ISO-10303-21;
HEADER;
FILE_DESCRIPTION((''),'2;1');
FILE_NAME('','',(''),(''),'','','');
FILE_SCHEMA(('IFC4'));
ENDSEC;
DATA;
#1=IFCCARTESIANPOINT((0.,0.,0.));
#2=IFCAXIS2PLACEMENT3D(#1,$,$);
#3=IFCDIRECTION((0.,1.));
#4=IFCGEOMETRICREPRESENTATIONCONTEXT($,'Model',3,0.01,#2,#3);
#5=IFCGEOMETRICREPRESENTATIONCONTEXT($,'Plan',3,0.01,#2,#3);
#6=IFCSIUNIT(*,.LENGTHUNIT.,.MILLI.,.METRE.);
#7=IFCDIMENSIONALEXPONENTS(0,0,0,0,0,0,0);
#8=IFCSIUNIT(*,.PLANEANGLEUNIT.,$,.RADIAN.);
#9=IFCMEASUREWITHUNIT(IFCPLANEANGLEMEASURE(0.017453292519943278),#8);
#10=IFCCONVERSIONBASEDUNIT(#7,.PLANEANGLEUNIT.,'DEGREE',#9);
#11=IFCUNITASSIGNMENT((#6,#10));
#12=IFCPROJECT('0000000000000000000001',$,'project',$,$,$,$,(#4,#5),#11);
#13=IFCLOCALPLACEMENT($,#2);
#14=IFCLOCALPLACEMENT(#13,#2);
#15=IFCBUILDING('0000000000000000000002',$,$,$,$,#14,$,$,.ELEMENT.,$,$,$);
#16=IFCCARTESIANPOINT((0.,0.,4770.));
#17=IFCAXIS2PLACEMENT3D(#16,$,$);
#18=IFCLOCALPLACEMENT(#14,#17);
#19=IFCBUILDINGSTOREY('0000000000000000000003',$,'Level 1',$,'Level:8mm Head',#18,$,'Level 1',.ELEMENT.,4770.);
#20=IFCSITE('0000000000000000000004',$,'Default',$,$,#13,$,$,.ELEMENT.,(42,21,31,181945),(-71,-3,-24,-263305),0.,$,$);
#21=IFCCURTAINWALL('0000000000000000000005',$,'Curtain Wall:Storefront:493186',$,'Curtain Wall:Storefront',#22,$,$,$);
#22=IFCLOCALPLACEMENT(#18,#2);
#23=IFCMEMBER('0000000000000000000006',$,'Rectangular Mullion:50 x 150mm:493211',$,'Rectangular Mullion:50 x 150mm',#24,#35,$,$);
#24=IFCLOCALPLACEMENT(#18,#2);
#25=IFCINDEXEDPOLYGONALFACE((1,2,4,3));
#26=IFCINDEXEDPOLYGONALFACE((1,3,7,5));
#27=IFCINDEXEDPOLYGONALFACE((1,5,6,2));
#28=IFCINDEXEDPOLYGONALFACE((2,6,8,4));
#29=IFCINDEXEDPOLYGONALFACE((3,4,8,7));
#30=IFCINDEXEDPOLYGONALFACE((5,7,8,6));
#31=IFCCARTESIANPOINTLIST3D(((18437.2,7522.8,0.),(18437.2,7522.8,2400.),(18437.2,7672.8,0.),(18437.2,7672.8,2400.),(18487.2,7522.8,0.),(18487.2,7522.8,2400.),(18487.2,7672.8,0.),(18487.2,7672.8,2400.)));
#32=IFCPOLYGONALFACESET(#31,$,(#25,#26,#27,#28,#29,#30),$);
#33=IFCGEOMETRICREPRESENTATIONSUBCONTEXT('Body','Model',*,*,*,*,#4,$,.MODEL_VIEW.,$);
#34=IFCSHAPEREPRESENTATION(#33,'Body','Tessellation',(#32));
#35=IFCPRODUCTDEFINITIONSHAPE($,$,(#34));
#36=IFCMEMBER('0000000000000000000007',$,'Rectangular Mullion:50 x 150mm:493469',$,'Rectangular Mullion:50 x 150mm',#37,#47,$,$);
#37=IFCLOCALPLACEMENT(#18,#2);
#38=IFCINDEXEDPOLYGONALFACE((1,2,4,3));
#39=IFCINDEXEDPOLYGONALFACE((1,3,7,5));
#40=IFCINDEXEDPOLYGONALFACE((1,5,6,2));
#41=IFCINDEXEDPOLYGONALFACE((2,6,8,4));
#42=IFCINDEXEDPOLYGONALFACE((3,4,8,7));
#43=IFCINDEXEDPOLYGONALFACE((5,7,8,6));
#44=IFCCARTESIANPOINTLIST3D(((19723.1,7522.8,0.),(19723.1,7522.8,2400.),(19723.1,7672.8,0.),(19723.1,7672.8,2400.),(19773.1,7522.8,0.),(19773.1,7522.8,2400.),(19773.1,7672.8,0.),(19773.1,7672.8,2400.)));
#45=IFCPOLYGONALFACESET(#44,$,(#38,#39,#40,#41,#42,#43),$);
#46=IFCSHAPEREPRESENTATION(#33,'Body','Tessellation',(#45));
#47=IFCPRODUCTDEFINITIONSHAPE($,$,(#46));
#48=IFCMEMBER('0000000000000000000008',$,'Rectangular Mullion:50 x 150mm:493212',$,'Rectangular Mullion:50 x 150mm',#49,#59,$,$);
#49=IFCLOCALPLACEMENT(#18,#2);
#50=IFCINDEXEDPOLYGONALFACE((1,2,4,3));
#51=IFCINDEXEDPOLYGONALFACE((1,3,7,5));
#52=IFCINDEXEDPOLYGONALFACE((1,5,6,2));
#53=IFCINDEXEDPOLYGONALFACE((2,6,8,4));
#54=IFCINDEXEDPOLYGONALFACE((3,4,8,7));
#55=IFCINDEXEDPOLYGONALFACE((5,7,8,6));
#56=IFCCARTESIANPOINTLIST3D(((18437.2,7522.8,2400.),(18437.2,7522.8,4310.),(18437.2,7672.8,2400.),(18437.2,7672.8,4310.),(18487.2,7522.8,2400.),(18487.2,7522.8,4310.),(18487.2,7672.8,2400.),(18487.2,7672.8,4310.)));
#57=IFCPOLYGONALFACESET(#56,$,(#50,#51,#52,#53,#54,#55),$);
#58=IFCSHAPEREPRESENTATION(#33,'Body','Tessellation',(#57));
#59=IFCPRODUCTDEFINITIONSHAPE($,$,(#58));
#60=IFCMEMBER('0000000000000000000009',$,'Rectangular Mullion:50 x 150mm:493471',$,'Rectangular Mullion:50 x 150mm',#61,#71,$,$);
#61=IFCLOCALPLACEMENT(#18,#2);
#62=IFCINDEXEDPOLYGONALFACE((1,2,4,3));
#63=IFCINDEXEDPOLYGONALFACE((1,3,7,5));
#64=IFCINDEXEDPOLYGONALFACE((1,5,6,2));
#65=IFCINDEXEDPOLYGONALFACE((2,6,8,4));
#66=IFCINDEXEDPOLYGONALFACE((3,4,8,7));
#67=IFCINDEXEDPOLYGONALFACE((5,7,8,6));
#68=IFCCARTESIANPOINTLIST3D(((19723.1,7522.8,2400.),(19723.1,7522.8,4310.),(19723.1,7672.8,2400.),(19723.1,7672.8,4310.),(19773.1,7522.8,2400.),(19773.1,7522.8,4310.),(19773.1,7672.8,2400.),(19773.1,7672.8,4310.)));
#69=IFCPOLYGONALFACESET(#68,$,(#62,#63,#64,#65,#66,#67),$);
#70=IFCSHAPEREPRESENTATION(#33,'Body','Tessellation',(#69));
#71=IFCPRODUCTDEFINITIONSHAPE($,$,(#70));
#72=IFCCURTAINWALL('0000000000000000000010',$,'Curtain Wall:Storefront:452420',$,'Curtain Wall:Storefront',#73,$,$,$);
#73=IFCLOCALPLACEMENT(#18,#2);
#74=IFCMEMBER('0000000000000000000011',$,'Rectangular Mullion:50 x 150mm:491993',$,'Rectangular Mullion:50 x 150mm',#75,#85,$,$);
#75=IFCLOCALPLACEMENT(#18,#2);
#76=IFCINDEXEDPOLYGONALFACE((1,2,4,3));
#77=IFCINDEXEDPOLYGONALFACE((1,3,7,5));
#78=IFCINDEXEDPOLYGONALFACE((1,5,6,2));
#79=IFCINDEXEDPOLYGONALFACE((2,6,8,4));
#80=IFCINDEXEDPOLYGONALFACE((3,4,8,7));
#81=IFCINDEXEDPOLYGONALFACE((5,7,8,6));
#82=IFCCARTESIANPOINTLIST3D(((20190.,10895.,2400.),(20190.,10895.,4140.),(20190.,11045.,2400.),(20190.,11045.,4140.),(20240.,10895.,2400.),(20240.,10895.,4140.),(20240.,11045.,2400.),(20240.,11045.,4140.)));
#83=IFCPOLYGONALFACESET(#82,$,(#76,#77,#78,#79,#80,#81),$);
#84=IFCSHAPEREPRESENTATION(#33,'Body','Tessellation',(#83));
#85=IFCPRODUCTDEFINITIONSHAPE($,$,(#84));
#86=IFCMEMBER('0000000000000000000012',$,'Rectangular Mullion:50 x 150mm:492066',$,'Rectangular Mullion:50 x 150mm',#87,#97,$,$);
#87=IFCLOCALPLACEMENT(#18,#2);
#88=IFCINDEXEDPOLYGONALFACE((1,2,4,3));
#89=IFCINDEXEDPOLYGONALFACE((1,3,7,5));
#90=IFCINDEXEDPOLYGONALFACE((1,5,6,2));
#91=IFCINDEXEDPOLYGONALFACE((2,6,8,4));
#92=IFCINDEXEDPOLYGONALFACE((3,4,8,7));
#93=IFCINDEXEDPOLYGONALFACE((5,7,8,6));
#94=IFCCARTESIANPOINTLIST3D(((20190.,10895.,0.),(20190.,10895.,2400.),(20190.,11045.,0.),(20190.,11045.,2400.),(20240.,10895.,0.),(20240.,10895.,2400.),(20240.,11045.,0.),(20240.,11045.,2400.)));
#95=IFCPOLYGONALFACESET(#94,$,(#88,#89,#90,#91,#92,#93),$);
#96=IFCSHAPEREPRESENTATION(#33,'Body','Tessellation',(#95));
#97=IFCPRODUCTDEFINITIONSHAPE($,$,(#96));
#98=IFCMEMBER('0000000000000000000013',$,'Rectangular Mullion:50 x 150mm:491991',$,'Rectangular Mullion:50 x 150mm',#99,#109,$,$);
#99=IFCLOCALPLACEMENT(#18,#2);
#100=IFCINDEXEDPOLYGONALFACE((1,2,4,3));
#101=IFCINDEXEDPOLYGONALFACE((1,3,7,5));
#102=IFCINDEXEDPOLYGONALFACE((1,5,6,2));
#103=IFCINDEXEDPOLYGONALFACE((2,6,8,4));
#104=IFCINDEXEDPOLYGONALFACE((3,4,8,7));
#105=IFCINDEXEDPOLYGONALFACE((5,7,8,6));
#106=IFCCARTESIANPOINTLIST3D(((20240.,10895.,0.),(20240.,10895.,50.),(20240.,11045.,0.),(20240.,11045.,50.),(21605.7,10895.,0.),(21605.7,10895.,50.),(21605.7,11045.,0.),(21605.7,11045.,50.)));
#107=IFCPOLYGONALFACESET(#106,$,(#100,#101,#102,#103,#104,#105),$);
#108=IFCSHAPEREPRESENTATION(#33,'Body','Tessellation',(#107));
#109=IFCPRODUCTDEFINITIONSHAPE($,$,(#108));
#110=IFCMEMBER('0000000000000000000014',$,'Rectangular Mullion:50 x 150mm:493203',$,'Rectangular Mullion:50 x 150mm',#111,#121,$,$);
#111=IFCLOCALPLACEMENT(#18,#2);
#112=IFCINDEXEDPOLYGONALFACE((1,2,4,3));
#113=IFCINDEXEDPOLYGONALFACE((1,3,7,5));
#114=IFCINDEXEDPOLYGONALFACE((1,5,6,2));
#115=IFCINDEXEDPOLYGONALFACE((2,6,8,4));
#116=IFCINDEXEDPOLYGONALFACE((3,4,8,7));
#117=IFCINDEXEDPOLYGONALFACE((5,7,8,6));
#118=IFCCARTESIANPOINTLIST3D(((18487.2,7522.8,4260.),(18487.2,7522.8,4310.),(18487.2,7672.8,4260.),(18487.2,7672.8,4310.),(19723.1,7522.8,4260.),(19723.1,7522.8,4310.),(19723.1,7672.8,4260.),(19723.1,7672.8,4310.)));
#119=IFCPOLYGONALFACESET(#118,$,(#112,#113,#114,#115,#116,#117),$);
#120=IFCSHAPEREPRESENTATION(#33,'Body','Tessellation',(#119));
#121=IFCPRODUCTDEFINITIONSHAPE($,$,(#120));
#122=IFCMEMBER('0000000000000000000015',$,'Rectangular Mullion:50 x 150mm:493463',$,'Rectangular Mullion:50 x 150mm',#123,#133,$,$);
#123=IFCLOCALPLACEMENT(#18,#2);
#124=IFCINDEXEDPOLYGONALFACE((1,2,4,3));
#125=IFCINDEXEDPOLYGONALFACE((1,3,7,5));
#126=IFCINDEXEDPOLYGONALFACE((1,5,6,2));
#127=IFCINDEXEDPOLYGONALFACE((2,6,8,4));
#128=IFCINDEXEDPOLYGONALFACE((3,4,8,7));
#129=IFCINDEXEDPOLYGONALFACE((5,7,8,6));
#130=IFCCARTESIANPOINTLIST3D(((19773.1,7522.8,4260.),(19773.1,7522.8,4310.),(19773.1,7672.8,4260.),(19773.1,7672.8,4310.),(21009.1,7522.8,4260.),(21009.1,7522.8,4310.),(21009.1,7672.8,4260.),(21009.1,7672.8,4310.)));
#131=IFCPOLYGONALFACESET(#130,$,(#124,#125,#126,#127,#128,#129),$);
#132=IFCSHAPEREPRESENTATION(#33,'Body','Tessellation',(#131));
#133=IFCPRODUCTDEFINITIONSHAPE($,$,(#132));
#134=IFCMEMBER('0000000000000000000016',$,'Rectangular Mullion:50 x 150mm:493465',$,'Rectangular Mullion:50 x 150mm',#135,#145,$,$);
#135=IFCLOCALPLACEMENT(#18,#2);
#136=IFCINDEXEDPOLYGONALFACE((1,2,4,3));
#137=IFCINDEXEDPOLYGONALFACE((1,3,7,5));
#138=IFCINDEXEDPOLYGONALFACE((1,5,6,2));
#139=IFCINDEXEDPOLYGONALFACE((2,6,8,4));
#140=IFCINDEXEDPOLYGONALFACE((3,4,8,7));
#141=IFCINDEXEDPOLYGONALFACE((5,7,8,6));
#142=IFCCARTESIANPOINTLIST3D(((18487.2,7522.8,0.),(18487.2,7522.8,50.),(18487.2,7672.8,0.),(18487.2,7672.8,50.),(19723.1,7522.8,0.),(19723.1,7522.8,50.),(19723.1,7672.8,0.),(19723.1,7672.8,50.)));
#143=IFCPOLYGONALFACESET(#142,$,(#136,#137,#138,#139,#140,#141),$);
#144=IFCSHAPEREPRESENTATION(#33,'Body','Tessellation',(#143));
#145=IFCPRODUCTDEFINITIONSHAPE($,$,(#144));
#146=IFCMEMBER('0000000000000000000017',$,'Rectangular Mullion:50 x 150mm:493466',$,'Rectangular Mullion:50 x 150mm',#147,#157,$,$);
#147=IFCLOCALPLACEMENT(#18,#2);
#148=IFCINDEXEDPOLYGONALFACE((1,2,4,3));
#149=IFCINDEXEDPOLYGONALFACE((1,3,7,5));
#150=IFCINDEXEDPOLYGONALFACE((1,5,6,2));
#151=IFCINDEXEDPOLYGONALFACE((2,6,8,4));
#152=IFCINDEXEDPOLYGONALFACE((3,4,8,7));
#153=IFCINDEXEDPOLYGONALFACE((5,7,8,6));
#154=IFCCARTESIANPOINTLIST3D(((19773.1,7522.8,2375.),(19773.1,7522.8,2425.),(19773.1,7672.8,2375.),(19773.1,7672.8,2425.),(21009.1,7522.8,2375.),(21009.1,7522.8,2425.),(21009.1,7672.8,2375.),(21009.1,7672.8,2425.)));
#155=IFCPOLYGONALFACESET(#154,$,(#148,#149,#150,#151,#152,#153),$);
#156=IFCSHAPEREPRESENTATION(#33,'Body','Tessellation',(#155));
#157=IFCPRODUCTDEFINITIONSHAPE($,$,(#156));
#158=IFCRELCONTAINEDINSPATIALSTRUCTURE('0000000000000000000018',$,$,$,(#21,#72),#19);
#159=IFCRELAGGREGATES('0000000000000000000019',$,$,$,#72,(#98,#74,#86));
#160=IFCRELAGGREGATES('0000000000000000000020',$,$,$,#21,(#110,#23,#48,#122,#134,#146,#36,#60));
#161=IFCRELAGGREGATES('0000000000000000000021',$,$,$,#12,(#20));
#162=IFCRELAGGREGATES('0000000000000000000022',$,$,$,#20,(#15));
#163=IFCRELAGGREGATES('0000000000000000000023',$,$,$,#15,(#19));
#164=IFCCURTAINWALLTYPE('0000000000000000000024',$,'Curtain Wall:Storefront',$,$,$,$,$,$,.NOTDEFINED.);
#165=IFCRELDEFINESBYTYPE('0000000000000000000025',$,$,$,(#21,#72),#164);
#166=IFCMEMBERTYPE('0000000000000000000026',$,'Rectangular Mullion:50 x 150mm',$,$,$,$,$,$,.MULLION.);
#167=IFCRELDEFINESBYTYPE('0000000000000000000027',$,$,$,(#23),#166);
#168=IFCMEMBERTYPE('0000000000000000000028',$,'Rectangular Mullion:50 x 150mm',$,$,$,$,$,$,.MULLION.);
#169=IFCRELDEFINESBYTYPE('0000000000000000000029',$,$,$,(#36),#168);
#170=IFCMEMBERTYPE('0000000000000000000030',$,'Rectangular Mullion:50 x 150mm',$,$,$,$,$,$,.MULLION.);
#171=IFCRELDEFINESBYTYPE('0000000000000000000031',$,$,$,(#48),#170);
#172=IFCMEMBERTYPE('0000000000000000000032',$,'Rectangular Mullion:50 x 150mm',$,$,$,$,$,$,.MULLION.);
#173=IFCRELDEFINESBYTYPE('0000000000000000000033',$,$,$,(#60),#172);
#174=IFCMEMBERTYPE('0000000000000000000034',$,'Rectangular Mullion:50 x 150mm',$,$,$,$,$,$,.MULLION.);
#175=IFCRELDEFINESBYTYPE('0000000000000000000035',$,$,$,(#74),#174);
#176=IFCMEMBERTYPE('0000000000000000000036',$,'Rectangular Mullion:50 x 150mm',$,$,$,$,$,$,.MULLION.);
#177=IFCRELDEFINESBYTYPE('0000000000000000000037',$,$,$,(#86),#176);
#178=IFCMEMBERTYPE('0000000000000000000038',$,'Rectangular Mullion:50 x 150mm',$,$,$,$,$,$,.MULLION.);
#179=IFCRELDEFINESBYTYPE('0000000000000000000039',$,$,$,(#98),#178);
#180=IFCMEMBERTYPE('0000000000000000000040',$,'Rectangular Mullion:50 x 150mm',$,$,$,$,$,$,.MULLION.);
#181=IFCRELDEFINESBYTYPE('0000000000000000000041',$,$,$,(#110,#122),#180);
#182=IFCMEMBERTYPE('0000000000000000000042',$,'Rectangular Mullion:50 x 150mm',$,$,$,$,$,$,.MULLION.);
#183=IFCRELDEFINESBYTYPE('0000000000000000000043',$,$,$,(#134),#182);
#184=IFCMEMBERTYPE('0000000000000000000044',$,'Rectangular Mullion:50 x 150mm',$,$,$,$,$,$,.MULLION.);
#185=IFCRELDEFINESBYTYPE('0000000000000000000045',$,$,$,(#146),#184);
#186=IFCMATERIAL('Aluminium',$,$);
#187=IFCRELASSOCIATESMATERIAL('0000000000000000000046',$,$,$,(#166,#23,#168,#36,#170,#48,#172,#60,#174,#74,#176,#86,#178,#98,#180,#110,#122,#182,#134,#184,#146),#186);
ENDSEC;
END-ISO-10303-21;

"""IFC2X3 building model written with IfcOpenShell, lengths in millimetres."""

from ifc_helpers import new_model, entity, si_unit, converted_unit, direction, frame, origin, origin_2d_with_axis, place, context, subcontext, project, spatial, rectangle, extrude, source, transform, mapped, material, type_object, type_shapes, element, aggregate, save


model = new_model("IFC2X3")

# Units and contexts
model_context = context("Model", 3, precision=0.01, world=origin(), true_north=direction((0.0, 1.0)))
plan_context = context("Plan", 3, precision=0.01, world=origin(), true_north=direction((0.0, 1.0)))
body_context = subcontext(model_context, "Body", "Model", "MODEL_VIEW")
ifc_project = project(units=[si_unit("LENGTHUNIT", "METRE", prefix="MILLI"), converted_unit("PLANEANGLEUNIT", "DEGREE", entity("IfcPlaneAngleMeasure", 0.017453292519943278), si_unit("PLANEANGLEUNIT", "RADIAN"), dimensions=[0, 0, 0, 0, 0, 0, 0])], contexts=[model_context, plan_context])

# Site, building, storey
site_placement = place(None, origin())
site = spatial("IfcSite", under=ifc_project, at=site_placement, Name="Default", CompositionType="ELEMENT", RefLatitude=(42, 21, 31, 181945), RefLongitude=(-71, -3, -24, -263305), RefElevation=0.0)
building_placement = place(site_placement, origin())
building = spatial("IfcBuilding", under=site, at=building_placement, CompositionType="ELEMENT")
storey_placement = place(building_placement, frame((0.0, 0.0, 4770.0)))
storey = spatial("IfcBuildingStorey", under=building, at=storey_placement, Name="Level 1", ObjectType="Level:8mm Head", LongName="Level 1", CompositionType="ELEMENT", Elevation=4770.0)

# Curtain walls, members
curtain_wall_type = type_object("IfcCurtainWallType", Name="Curtain Wall:Storefront", PredefinedType="NOTDEFINED")
curtain_wall_1_placement = place(storey_placement, frame((0.0, 0.0, -4770.0)))
curtain_wall_1 = element("IfcCurtainWall", 1, at=curtain_wall_1_placement, inside=storey, type_object=curtain_wall_type, Name="Curtain Wall:Storefront:493186", ObjectType="Curtain Wall:Storefront")
ifc_material_1 = material(Name="Aluminium")
member_type_1 = type_object("IfcMemberType", Name="Rectangular Mullion:50 x 150mm", PredefinedType="MULLION", material=ifc_material_1)
shared_shape_1 = source(origin(), body_context, "Body", "SweptSolid", [
    extrude(rectangle(XDim=50.0, YDim=150.0, at=origin_2d_with_axis()), frame((-25.0, 0.0, -2400.0), z_axis=(0.0, 0.0, 1.0), x_axis=(-1.0, 0.0, 0.0)), (0.0, 0.0, 1.0), 2400.0),
])
type_shapes(member_type_1, [shared_shape_1])
member_1_placement = place(curtain_wall_1_placement, frame((18437.2, 7597.8, 4770.0), z_axis=(0.0, 0.0, -1.0), x_axis=(-1.0, 0.0, 0.0)))
member_1 = element("IfcMember", 2, at=member_1_placement, type_object=member_type_1, material=ifc_material_1, Name="Rectangular Mullion:50 x 150mm:493211", ObjectType="Rectangular Mullion:50 x 150mm", context=body_context, shape_type="MappedRepresentation", body=[
    mapped(shared_shape_1, transform((0.0, 0.0, 0.0), scale=1.0)),
])
member_type_2 = type_object("IfcMemberType", Name="Rectangular Mullion:50 x 150mm", PredefinedType="MULLION", material=ifc_material_1)
shared_shape_2 = source(origin(), body_context, "Body", "SweptSolid", [
    extrude(rectangle(XDim=50.0, YDim=150.0, at=origin_2d_with_axis()), frame((0.0, 0.0, -2400.0), z_axis=(0.0, 0.0, 1.0), x_axis=(-1.0, 0.0, 0.0)), (0.0, 0.0, 1.0), 2400.0),
])
type_shapes(member_type_2, [shared_shape_2])
member_2_placement = place(curtain_wall_1_placement, frame((19748.1, 7597.8, 4770.0), z_axis=(0.0, 0.0, -1.0), x_axis=(-1.0, 0.0, 0.0)))
member_2 = element("IfcMember", 3, at=member_2_placement, type_object=member_type_2, material=ifc_material_1, Name="Rectangular Mullion:50 x 150mm:493469", ObjectType="Rectangular Mullion:50 x 150mm", context=body_context, shape_type="MappedRepresentation", body=[
    mapped(shared_shape_2, transform((0.0, 0.0, 0.0), scale=1.0)),
])
member_type_3 = type_object("IfcMemberType", Name="Rectangular Mullion:50 x 150mm", PredefinedType="MULLION", material=ifc_material_1)
shared_shape_3 = source(origin(), body_context, "Body", "SweptSolid", [
    extrude(rectangle(XDim=50.0, YDim=150.0, at=origin_2d_with_axis()), frame((-25.0, 0.0, -1910.0), z_axis=(0.0, 0.0, 1.0), x_axis=(-1.0, 0.0, 0.0)), (0.0, 0.0, 1.0), 1910.0),
])
type_shapes(member_type_3, [shared_shape_3])
member_3_placement = place(curtain_wall_1_placement, frame((18437.2, 7597.8, 7170.0), z_axis=(0.0, 0.0, -1.0), x_axis=(-1.0, 0.0, 0.0)))
member_3 = element("IfcMember", 4, at=member_3_placement, type_object=member_type_3, material=ifc_material_1, Name="Rectangular Mullion:50 x 150mm:493212", ObjectType="Rectangular Mullion:50 x 150mm", context=body_context, shape_type="MappedRepresentation", body=[
    mapped(shared_shape_3, transform((0.0, 0.0, 0.0), scale=1.0)),
])
member_type_4 = type_object("IfcMemberType", Name="Rectangular Mullion:50 x 150mm", PredefinedType="MULLION", material=ifc_material_1)
shared_shape_4 = source(origin(), body_context, "Body", "SweptSolid", [
    extrude(rectangle(XDim=50.0, YDim=150.0, at=origin_2d_with_axis()), frame((0.0, 0.0, -1910.0), z_axis=(0.0, 0.0, 1.0), x_axis=(-1.0, 0.0, 0.0)), (0.0, 0.0, 1.0), 1910.0),
])
type_shapes(member_type_4, [shared_shape_4])
member_4_placement = place(curtain_wall_1_placement, frame((19748.1, 7597.8, 7170.0), z_axis=(0.0, 0.0, -1.0), x_axis=(-1.0, 0.0, 0.0)))
member_4 = element("IfcMember", 5, at=member_4_placement, type_object=member_type_4, material=ifc_material_1, Name="Rectangular Mullion:50 x 150mm:493471", ObjectType="Rectangular Mullion:50 x 150mm", context=body_context, shape_type="MappedRepresentation", body=[
    mapped(shared_shape_4, transform((0.0, 0.0, 0.0), scale=1.0)),
])
curtain_wall_2_placement = place(storey_placement, frame((0.0, 0.0, -4770.0)))
curtain_wall_2 = element("IfcCurtainWall", 6, at=curtain_wall_2_placement, inside=storey, type_object=curtain_wall_type, Name="Curtain Wall:Storefront:452420", ObjectType="Curtain Wall:Storefront")
member_type_5 = type_object("IfcMemberType", Name="Rectangular Mullion:50 x 150mm", PredefinedType="MULLION", material=ifc_material_1)
shared_shape_5 = source(origin(), body_context, "Body", "SweptSolid", [
    extrude(rectangle(XDim=50.0, YDim=150.0, at=origin_2d_with_axis()), frame((-25.0, 0.0, -1740.0), z_axis=(0.0, 0.0, 1.0), x_axis=(-1.0, 0.0, 0.0)), (0.0, 0.0, 1.0), 1740.0),
])
type_shapes(member_type_5, [shared_shape_5])
member_5_placement = place(curtain_wall_2_placement, frame((20190.0, 10970.0, 8910.0), z_axis=(0.0, 0.0, 1.0), x_axis=(-1.0, 0.0, 0.0)))
member_5 = element("IfcMember", 7, at=member_5_placement, type_object=member_type_5, material=ifc_material_1, Name="Rectangular Mullion:50 x 150mm:491993", ObjectType="Rectangular Mullion:50 x 150mm", context=body_context, shape_type="MappedRepresentation", body=[
    mapped(shared_shape_5, transform((0.0, 0.0, 0.0), scale=1.0)),
])
member_type_6 = type_object("IfcMemberType", Name="Rectangular Mullion:50 x 150mm", PredefinedType="MULLION", material=ifc_material_1)
shared_shape_6 = source(origin(), body_context, "Body", "SweptSolid", [
    extrude(rectangle(XDim=50.0, YDim=150.0, at=origin_2d_with_axis()), frame((-25.0, 0.0, -2400.0), z_axis=(0.0, 0.0, 1.0), x_axis=(-1.0, 0.0, 0.0)), (0.0, 0.0, 1.0), 2400.0),
])
type_shapes(member_type_6, [shared_shape_6])
member_6_placement = place(curtain_wall_2_placement, frame((20190.0, 10970.0, 7170.0), z_axis=(0.0, 0.0, 1.0), x_axis=(-1.0, 0.0, 0.0)))
member_6 = element("IfcMember", 8, at=member_6_placement, type_object=member_type_6, material=ifc_material_1, Name="Rectangular Mullion:50 x 150mm:492066", ObjectType="Rectangular Mullion:50 x 150mm", context=body_context, shape_type="MappedRepresentation", body=[
    mapped(shared_shape_6, transform((0.0, 0.0, 0.0), scale=1.0)),
])
member_type_7 = type_object("IfcMemberType", Name="Rectangular Mullion:50 x 150mm", PredefinedType="MULLION", material=ifc_material_1)
shared_shape_7 = source(origin(), body_context, "Body", "SweptSolid", [
    extrude(rectangle(XDim=50.0, YDim=150.0, at=origin_2d_with_axis()), frame((-25.0, 0.0, -1365.7), z_axis=(0.0, 0.0, 1.0), x_axis=(-1.0, 0.0, 0.0)), (0.0, 0.0, 1.0), 1365.7),
])
type_shapes(member_type_7, [shared_shape_7])
member_7_placement = place(curtain_wall_2_placement, frame((20240.0, 10970.0, 4770.0), z_axis=(-1.0, 0.0, 0.0), x_axis=(0.0, 0.0, -1.0)))
member_7 = element("IfcMember", 9, at=member_7_placement, type_object=member_type_7, material=ifc_material_1, Name="Rectangular Mullion:50 x 150mm:491991", ObjectType="Rectangular Mullion:50 x 150mm", context=body_context, shape_type="MappedRepresentation", body=[
    mapped(shared_shape_7, transform((0.0, 0.0, 0.0), scale=1.0)),
])
aggregate(curtain_wall_2, [member_7, member_5, member_6])

# Members
member_type_8 = type_object("IfcMemberType", Name="Rectangular Mullion:50 x 150mm", PredefinedType="MULLION", material=ifc_material_1)
shared_shape_8 = source(origin(), body_context, "Body", "SweptSolid", [
    extrude(rectangle(XDim=50.0, YDim=150.0, at=origin_2d_with_axis()), frame((-25.0, 0.0, -1236.0), z_axis=(0.0, 0.0, 1.0), x_axis=(-1.0, 0.0, 0.0)), (0.0, 0.0, 1.0), 1236.0),
])
type_shapes(member_type_8, [shared_shape_8])
member_8_placement = place(curtain_wall_1_placement, frame((18487.2, 7597.8, 9080.0), z_axis=(-1.0, 0.0, 0.0), x_axis=(0.0, 0.0, 1.0)))
member_8 = element("IfcMember", 10, at=member_8_placement, type_object=member_type_8, material=ifc_material_1, Name="Rectangular Mullion:50 x 150mm:493203", ObjectType="Rectangular Mullion:50 x 150mm", context=body_context, shape_type="MappedRepresentation", body=[
    mapped(shared_shape_8, transform((0.0, 0.0, 0.0), scale=1.0)),
])
member_9_placement = place(curtain_wall_1_placement, frame((19773.1, 7597.8, 9080.0), z_axis=(-1.0, 0.0, 0.0), x_axis=(0.0, 0.0, 1.0)))
member_9 = element("IfcMember", 11, at=member_9_placement, type_object=member_type_8, material=ifc_material_1, Name="Rectangular Mullion:50 x 150mm:493463", ObjectType="Rectangular Mullion:50 x 150mm", context=body_context, shape_type="MappedRepresentation", body=[
    mapped(shared_shape_8, transform((0.0, 0.0, 0.0), scale=1.0)),
])
member_type_9 = type_object("IfcMemberType", Name="Rectangular Mullion:50 x 150mm", PredefinedType="MULLION", material=ifc_material_1)
shared_shape_9 = source(origin(), body_context, "Body", "SweptSolid", [
    extrude(rectangle(XDim=50.0, YDim=150.0, at=origin_2d_with_axis()), frame((-25.0, 0.0, -1236.0), z_axis=(0.0, 0.0, 1.0), x_axis=(-1.0, 0.0, 0.0)), (0.0, 0.0, 1.0), 1236.0),
])
type_shapes(member_type_9, [shared_shape_9])
member_10_placement = place(curtain_wall_1_placement, frame((19723.1, 7597.8, 4770.0), z_axis=(1.0, 0.0, 0.0), x_axis=(0.0, 0.0, -1.0)))
member_10 = element("IfcMember", 12, at=member_10_placement, type_object=member_type_9, material=ifc_material_1, Name="Rectangular Mullion:50 x 150mm:493465", ObjectType="Rectangular Mullion:50 x 150mm", context=body_context, shape_type="MappedRepresentation", body=[
    mapped(shared_shape_9, transform((0.0, 0.0, 0.0), scale=1.0)),
])
member_type_10 = type_object("IfcMemberType", Name="Rectangular Mullion:50 x 150mm", PredefinedType="MULLION", material=ifc_material_1)
shared_shape_10 = source(origin(), body_context, "Body", "SweptSolid", [
    extrude(rectangle(XDim=50.0, YDim=150.0, at=origin_2d_with_axis()), frame((0.0, 0.0, -1236.0), z_axis=(0.0, 0.0, 1.0), x_axis=(-1.0, 0.0, 0.0)), (0.0, 0.0, 1.0), 1236.0),
])
type_shapes(member_type_10, [shared_shape_10])
member_11_placement = place(curtain_wall_1_placement, frame((19773.1, 7597.8, 7170.0), z_axis=(-1.0, 0.0, 0.0), x_axis=(0.0, 0.0, 1.0)))
member_11 = element("IfcMember", 13, at=member_11_placement, type_object=member_type_10, material=ifc_material_1, Name="Rectangular Mullion:50 x 150mm:493466", ObjectType="Rectangular Mullion:50 x 150mm", context=body_context, shape_type="MappedRepresentation", body=[
    mapped(shared_shape_10, transform((0.0, 0.0, 0.0), scale=1.0)),
])

aggregate(curtain_wall_1, [member_8, member_1, member_3, member_9, member_10, member_11, member_2, member_4])

save(model, "model.ifc")
